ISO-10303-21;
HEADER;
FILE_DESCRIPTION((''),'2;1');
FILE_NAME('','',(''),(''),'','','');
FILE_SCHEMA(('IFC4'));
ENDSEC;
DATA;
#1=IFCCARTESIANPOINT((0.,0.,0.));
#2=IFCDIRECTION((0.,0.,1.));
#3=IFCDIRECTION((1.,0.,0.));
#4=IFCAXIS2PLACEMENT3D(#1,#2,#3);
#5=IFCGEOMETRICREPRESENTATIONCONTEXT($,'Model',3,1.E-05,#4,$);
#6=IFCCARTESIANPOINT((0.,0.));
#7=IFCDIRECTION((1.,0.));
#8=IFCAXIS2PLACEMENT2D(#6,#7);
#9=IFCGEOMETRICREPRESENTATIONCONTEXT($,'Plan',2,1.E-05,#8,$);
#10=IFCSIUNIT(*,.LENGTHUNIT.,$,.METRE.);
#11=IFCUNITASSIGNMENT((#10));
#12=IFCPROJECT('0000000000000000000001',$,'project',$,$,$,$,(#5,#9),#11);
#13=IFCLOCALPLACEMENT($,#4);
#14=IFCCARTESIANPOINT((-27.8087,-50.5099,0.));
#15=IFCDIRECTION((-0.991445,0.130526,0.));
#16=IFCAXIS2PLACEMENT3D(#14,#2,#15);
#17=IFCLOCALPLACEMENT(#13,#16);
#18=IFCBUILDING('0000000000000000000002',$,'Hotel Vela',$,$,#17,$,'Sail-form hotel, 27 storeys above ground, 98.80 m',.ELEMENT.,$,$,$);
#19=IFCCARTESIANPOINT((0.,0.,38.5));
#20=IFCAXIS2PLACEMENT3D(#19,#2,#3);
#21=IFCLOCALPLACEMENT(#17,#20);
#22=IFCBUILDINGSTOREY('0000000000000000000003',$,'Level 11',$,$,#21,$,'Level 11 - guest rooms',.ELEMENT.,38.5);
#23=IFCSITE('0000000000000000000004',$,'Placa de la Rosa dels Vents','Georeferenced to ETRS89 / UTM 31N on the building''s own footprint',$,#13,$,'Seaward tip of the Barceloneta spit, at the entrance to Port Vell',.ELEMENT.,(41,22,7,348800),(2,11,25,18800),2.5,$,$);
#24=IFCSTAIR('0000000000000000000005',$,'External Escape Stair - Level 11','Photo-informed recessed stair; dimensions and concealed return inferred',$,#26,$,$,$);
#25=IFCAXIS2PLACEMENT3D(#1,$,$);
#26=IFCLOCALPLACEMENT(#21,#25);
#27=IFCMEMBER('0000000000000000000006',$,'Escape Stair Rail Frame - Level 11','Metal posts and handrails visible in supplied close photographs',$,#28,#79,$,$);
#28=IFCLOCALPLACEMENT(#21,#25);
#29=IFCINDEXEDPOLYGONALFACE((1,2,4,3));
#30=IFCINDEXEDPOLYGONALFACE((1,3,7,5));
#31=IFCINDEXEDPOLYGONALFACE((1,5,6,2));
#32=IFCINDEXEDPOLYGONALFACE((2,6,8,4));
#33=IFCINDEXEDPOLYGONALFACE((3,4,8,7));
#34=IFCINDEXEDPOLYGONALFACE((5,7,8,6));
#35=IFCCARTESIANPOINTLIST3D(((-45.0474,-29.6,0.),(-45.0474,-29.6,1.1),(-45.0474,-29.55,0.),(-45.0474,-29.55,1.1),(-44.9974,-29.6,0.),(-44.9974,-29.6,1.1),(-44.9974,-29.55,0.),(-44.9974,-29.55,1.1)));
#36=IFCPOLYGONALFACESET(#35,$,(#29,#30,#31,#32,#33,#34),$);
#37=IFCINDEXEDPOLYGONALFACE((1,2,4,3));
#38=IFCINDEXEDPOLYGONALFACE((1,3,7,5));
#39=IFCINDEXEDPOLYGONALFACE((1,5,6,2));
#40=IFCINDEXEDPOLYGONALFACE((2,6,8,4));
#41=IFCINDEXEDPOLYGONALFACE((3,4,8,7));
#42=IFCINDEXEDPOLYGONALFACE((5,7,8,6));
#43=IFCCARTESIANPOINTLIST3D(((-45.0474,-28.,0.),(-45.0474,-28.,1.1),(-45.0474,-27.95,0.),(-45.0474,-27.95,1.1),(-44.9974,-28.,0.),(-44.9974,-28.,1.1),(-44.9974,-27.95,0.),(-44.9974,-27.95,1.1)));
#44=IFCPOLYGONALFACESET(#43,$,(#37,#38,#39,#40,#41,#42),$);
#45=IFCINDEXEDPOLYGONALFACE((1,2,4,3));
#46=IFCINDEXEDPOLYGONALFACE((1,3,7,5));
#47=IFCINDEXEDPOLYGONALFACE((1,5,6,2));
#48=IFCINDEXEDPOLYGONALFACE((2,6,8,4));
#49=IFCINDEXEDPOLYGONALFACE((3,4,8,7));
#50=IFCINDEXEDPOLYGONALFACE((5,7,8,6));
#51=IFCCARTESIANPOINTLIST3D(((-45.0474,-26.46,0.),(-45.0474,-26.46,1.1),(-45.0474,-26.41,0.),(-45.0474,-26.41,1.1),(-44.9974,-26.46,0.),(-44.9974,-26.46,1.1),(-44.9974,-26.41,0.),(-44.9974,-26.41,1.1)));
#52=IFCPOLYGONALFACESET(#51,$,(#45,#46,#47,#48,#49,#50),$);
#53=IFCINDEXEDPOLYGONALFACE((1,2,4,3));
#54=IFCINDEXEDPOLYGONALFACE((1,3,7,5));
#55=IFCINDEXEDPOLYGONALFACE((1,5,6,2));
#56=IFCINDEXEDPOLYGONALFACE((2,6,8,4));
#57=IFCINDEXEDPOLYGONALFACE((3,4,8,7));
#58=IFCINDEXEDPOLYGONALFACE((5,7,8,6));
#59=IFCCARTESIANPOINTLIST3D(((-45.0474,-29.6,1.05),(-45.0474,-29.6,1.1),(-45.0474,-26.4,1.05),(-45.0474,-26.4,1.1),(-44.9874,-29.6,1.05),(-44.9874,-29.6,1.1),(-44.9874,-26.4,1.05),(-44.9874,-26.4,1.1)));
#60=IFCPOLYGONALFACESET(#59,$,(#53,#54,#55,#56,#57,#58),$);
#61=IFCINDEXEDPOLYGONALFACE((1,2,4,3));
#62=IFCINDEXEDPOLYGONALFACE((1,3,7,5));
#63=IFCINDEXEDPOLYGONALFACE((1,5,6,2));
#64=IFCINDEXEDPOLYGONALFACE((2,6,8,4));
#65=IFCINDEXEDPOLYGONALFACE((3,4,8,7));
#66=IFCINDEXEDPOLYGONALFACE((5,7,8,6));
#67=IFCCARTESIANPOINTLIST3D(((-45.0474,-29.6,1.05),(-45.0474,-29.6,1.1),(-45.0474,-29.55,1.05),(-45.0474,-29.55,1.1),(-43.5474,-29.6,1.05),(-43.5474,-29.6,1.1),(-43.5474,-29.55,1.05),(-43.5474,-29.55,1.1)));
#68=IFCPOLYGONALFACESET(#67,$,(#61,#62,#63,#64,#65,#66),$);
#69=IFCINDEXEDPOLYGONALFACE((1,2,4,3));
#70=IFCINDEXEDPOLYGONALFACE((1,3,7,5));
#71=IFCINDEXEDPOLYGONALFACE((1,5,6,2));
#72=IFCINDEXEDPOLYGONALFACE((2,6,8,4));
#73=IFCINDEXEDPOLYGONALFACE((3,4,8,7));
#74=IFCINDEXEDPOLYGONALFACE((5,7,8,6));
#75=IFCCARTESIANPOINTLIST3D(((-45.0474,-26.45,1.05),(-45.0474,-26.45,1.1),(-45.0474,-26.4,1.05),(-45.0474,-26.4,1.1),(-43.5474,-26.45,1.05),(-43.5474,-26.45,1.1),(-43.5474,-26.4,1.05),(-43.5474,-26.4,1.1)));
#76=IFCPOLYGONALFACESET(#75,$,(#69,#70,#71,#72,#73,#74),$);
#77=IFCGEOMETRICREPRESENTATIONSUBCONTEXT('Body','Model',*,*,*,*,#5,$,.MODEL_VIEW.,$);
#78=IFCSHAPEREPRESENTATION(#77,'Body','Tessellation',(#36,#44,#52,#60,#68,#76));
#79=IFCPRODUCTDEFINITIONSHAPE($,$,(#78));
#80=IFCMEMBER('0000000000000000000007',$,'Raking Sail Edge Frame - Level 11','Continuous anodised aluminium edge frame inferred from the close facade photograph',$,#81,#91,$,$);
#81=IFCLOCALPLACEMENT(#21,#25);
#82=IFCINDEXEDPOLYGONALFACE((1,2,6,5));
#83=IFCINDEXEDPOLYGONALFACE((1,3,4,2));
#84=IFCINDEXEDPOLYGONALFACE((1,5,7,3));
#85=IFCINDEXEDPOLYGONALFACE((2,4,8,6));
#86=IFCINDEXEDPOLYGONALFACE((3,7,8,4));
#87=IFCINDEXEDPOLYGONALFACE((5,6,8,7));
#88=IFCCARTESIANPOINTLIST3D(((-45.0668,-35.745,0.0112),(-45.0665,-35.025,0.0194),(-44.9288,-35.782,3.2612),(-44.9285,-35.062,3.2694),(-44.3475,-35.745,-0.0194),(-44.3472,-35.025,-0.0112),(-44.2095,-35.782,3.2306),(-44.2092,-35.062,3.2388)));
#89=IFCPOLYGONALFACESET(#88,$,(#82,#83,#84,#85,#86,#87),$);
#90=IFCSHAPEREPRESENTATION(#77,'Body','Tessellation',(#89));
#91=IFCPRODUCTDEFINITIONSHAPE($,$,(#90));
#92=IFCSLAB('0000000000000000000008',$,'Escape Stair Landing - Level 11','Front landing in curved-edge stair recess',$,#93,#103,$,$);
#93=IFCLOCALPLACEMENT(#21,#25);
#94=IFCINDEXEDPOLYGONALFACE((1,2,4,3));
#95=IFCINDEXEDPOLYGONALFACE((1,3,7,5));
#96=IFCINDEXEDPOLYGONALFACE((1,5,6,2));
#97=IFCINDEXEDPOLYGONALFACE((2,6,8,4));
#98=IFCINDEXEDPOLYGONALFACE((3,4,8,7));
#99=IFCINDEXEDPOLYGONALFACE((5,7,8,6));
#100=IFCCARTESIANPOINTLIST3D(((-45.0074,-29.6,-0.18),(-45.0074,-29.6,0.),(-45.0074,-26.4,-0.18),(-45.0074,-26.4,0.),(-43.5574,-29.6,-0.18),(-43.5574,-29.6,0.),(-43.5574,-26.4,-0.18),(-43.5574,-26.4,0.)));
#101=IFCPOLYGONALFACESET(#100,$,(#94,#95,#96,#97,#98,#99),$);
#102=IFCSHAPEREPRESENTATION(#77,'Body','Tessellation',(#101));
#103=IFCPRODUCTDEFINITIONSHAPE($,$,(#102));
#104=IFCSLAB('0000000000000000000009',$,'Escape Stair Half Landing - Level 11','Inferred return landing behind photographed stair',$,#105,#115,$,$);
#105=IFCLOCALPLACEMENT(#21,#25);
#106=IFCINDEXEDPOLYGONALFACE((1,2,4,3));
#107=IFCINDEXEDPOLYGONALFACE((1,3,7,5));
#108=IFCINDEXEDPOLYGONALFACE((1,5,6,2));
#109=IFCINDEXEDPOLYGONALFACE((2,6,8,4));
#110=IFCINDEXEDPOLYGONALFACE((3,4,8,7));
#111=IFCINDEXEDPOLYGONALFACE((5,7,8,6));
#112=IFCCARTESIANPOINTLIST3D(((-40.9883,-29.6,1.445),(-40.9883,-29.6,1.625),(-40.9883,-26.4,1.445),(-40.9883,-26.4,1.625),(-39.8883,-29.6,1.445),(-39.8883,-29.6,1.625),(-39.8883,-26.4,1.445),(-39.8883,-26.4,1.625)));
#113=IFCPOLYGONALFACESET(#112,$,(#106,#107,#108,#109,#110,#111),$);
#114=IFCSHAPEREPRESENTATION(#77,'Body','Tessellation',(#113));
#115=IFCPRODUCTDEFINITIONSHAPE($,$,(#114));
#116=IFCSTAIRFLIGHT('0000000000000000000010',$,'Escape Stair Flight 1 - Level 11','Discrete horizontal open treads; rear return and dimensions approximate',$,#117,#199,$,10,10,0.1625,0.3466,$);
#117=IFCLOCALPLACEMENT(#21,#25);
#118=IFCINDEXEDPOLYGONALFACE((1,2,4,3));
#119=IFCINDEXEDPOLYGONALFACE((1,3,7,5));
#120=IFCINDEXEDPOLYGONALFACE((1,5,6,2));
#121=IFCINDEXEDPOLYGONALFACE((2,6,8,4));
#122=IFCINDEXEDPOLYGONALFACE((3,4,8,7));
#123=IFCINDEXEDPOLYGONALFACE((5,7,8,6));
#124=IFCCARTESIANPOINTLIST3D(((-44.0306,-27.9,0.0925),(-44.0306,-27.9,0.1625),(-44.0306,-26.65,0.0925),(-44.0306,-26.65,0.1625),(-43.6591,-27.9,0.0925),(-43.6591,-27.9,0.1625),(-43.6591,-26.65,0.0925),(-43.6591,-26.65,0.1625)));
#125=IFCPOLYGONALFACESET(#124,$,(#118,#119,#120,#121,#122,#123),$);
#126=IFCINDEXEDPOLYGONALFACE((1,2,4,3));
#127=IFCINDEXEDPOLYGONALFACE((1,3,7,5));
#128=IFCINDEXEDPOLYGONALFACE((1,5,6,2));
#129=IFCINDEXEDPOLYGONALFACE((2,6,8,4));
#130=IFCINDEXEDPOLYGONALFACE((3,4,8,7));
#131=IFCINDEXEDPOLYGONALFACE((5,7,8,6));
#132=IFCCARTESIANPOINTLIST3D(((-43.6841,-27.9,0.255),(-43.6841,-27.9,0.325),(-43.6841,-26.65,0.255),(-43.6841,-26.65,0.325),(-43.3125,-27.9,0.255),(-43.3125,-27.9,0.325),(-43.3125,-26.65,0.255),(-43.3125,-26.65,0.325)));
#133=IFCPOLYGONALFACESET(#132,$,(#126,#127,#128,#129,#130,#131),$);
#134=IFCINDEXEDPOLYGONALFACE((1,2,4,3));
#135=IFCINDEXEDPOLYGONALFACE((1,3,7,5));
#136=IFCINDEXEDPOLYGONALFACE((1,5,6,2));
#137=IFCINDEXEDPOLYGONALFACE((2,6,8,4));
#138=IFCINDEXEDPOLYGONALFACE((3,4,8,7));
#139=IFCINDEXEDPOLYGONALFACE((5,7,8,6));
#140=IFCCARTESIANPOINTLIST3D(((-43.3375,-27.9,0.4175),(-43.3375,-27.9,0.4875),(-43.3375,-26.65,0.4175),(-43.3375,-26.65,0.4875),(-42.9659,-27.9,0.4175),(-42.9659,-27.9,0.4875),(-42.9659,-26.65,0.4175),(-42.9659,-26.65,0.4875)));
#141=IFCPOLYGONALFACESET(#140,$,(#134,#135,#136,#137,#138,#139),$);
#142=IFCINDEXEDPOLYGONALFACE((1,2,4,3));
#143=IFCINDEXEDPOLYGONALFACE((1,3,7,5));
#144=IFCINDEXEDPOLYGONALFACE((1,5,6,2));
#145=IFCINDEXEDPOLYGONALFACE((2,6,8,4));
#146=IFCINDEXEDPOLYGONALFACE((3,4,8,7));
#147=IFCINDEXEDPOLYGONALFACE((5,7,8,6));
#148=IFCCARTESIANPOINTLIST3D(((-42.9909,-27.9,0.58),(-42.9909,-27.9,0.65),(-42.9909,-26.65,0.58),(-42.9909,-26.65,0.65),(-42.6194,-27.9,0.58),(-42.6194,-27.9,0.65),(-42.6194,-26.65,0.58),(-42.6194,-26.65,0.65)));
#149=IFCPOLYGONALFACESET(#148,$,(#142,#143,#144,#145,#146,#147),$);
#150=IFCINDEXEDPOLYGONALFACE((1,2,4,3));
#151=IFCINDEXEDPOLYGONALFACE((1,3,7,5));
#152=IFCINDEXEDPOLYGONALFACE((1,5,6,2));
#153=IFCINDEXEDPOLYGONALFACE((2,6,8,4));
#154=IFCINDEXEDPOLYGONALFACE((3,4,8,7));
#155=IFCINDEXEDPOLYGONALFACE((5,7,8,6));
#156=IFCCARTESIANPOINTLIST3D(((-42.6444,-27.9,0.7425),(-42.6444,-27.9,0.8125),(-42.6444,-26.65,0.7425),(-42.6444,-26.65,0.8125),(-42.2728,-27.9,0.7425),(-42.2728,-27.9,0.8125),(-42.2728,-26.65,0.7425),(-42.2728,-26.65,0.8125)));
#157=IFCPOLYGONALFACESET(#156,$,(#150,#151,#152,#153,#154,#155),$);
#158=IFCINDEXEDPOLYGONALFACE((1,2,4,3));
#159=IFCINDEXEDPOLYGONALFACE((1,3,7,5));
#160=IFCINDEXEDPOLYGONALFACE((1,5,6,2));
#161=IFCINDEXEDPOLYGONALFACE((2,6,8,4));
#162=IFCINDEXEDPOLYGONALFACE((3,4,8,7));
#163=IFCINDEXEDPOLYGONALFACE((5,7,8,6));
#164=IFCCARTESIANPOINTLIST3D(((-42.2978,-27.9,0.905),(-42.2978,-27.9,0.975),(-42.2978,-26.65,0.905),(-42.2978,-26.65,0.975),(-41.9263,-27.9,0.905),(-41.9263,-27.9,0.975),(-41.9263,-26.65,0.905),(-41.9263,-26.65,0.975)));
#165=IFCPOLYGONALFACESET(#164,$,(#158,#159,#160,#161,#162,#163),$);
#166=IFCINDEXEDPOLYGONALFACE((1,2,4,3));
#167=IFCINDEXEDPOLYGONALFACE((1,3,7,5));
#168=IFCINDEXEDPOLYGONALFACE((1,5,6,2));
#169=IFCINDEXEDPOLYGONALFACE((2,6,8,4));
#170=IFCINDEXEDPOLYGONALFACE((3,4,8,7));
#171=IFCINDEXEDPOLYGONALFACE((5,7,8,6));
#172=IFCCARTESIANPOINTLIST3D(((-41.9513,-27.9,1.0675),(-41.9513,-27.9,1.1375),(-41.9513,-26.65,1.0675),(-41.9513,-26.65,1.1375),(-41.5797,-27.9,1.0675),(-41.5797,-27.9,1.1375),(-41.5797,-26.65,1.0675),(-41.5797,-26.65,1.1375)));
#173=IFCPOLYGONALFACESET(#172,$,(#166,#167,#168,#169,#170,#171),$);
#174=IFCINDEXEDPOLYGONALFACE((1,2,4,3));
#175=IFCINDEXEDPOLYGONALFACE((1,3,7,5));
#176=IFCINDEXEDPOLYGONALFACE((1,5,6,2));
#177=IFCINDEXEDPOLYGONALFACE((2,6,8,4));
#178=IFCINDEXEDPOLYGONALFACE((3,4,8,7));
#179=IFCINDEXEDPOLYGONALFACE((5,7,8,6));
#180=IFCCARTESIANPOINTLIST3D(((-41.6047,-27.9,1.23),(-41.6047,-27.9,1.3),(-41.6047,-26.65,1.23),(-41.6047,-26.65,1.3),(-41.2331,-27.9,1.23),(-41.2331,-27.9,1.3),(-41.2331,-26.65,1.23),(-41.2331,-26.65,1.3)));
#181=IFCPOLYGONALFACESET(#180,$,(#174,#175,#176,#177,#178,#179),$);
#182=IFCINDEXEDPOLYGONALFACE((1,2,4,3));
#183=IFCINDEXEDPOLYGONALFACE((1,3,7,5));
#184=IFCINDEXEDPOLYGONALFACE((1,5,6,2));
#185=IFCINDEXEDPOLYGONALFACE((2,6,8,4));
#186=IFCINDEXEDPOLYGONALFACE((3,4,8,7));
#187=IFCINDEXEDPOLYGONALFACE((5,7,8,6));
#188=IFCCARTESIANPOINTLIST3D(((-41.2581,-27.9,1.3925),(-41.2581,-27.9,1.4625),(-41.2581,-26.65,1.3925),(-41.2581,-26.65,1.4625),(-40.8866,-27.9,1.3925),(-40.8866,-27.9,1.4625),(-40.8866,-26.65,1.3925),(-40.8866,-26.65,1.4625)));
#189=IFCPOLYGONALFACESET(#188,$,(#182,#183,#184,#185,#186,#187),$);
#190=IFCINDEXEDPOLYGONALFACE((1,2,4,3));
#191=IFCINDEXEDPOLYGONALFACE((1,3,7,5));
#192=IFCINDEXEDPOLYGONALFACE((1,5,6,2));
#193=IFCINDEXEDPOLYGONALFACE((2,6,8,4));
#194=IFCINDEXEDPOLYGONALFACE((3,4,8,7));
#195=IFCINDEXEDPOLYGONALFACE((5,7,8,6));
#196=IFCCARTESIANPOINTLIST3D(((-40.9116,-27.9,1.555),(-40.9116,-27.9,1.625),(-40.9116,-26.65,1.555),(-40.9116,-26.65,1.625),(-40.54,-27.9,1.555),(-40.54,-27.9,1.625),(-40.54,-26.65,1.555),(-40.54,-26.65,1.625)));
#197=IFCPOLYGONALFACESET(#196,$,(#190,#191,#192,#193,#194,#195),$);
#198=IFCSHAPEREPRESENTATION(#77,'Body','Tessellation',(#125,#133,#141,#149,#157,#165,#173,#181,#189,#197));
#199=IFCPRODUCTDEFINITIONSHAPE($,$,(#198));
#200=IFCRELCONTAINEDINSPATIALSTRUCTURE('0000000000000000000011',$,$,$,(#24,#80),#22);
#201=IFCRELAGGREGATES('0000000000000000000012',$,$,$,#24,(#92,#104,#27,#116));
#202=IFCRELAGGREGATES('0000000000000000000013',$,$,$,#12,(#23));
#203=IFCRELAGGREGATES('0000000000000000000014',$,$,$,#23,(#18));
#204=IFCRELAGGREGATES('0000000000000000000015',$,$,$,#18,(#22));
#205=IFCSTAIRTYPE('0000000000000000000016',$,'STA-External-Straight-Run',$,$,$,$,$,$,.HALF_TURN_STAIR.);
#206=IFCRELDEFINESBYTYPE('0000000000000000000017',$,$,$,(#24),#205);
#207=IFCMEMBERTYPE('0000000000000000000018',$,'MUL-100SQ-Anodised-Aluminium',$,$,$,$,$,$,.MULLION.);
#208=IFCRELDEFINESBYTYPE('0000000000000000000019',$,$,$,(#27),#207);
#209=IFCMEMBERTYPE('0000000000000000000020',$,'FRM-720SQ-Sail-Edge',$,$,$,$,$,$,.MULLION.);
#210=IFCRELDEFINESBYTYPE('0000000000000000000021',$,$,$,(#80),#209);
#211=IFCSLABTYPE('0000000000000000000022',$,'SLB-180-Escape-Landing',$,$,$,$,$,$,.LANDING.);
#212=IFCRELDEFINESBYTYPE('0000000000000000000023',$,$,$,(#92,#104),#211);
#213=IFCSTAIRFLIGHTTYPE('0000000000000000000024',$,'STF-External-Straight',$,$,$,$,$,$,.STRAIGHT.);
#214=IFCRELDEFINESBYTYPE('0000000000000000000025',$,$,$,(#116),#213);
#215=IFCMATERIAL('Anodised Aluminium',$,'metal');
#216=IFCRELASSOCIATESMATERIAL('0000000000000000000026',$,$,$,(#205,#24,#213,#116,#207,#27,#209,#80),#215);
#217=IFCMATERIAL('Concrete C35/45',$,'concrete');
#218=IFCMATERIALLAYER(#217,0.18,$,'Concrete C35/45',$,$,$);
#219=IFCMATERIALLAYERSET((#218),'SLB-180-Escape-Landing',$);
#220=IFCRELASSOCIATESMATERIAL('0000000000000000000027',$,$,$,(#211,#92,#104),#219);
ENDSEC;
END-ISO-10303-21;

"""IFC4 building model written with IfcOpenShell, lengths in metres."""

from ifc_helpers import new_model, si_unit, frame, origin_with_axes, origin_2d_with_axis, place, context, subcontext, project, spatial, line, indexed_curve, rectangle, outline, extrude, material, layer, layer_set, layer_usage, material_profile, profile_set, profile_usage, type_object, element, aggregate, save


model = new_model("IFC4")

# Units and contexts
model_context = context("Model", 3, precision=1e-05, world=origin_with_axes())
plan_context = context("Plan", 2, precision=1e-05, world=origin_2d_with_axis())
body_context = subcontext(model_context, "Body", "Model", "MODEL_VIEW")
ifc_project = project(units=[si_unit("LENGTHUNIT", "METRE")], contexts=[model_context, plan_context])

# Site, building, storey
site_placement = place(None, origin_with_axes())
site = spatial("IfcSite", under=ifc_project, at=site_placement, Name="Placa de la Rosa dels Vents", Description="Georeferenced to ETRS89 / UTM 31N on the building's own footprint", LongName="Seaward tip of the Barceloneta spit, at the entrance to Port Vell", CompositionType="ELEMENT", RefLatitude=(41, 22, 7, 348800), RefLongitude=(2, 11, 25, 18800), RefElevation=2.5)
building_placement = place(site_placement, frame((-27.8087, -50.5099, 0.0), z_axis=(0.0, 0.0, 1.0), x_axis=(-0.991445, 0.130526, 0.0)))
building = spatial("IfcBuilding", under=site, at=building_placement, Name="Hotel Vela", LongName="Sail-form hotel, 27 storeys above ground, 98.80 m", CompositionType="ELEMENT")
storey_placement = place(building_placement, frame((0.0, 0.0, 38.5), z_axis=(0.0, 0.0, 1.0), x_axis=(1.0, 0.0, 0.0)))
storey = spatial("IfcBuildingStorey", under=building, at=storey_placement, Name="Level 11", LongName="Level 11 - guest rooms", CompositionType="ELEMENT", Elevation=38.5)

# Stair, member
ifc_material_1 = material(Name="Anodised Aluminium", Category="metal")
stair_type = type_object("IfcStairType", Name="STA-External-Straight-Run", PredefinedType="HALF_TURN_STAIR", material=ifc_material_1)
stair_placement = place(storey_placement, frame((0.0, 0.0, -38.5), z_axis=(0.0, 0.0, 1.0), x_axis=(1.0, 0.0, 0.0)))
stair = element("IfcStair", 1, at=stair_placement, inside=storey, type_object=stair_type, material=ifc_material_1, Name="External Escape Stair - Level 11", Description="Photo-informed recessed stair; dimensions and concealed return inferred")
ifc_material_profile_1 = material_profile(ifc_material_1, rectangle(XDim=0.1, YDim=0.1))
ifc_profile_set_1 = profile_set([ifc_material_profile_1], Name="MUL-100SQ-Anodised-Aluminium")
ifc_profile_usage_1 = profile_usage(ifc_profile_set_1)
member_type_1 = type_object("IfcMemberType", Name="MUL-100SQ-Anodised-Aluminium", PredefinedType="MULLION", material=ifc_profile_set_1)
member_1_placement = place(stair_placement, origin_with_axes())
member_1 = element("IfcMember", 2, at=member_1_placement, type_object=member_type_1, material=ifc_profile_usage_1, Name="Escape Stair Rail Frame - Level 11", Description="Metal posts and handrails visible in supplied close photographs", context=body_context, shape_type="SweptSolid", body=[
    extrude(outline(indexed_curve([(0.0, 0.0), (0.05, 0.0), (0.05, 0.05), (0.0, 0.05)], segments=[line(1, 2, 3, 4, 1)])), frame((-45.0474, -29.6, 38.5), z_axis=(0.0, 0.0, 1.0), x_axis=(1.0, 0.0, 0.0)), (0.0, 0.0, 1.0), 1.1),
    extrude(outline(indexed_curve([(0.0, 0.0), (0.05, 0.0), (0.05, 0.05), (0.0, 0.05)], segments=[line(1, 2, 3, 4, 1)])), frame((-45.0474, -28.0, 38.5), z_axis=(0.0, 0.0, 1.0), x_axis=(1.0, 0.0, 0.0)), (0.0, 0.0, 1.0), 1.1),
    extrude(outline(indexed_curve([(0.0, 0.0), (0.05, 0.0), (0.05, 0.05), (0.0, 0.05)], segments=[line(1, 2, 3, 4, 1)])), frame((-45.0474, -26.46, 38.5), z_axis=(0.0, 0.0, 1.0), x_axis=(1.0, 0.0, 0.0)), (0.0, 0.0, 1.0), 1.1),
    extrude(outline(indexed_curve([(0.0, 0.0), (0.06, 0.0), (0.06, 3.2), (0.0, 3.2)], segments=[line(1, 2, 3, 4, 1)])), frame((-45.0474, -29.6, 39.55), z_axis=(0.0, 0.0, 1.0), x_axis=(1.0, 0.0, 0.0)), (0.0, 0.0, 1.0), 0.05),
    extrude(outline(indexed_curve([(0.0, 0.0), (1.5, 0.0), (1.5, 0.05), (0.0, 0.05)], segments=[line(1, 2, 3, 4, 1)])), frame((-45.0474, -29.6, 39.55), z_axis=(0.0, 0.0, 1.0), x_axis=(1.0, 0.0, 0.0)), (0.0, 0.0, 1.0), 0.05),
    extrude(outline(indexed_curve([(0.0, 0.0), (1.5, 0.0), (1.5, 0.05), (0.0, 0.05)], segments=[line(1, 2, 3, 4, 1)])), frame((-45.0474, -26.45, 39.55), z_axis=(0.0, 0.0, 1.0), x_axis=(1.0, 0.0, 0.0)), (0.0, 0.0, 1.0), 0.05),
])

# Member
ifc_material_profile_2 = material_profile(ifc_material_1, rectangle(XDim=0.72, YDim=0.72))
ifc_profile_set_2 = profile_set([ifc_material_profile_2], Name="FRM-720SQ-Sail-Edge")
ifc_profile_usage_2 = profile_usage(ifc_profile_set_2)
member_type_2 = type_object("IfcMemberType", Name="FRM-720SQ-Sail-Edge", PredefinedType="MULLION", material=ifc_profile_set_2)
member_2_placement = place(storey_placement, frame((-44.707, -35.385, 0.0), z_axis=(0.042421, -0.011374, 0.999035), x_axis=(0.9991, 0.0, -0.042423)))
element("IfcMember", 3, at=member_2_placement, inside=storey, type_object=member_type_2, material=ifc_profile_usage_2, Name="Raking Sail Edge Frame - Level 11", Description="Continuous anodised aluminium edge frame inferred from the close facade photograph", context=body_context, shape_type="SweptSolid", body=[
    extrude(outline(indexed_curve([(-0.36, -0.36), (0.36, -0.36), (0.36, 0.36), (-0.36, 0.36)], segments=[line(1, 2, 3, 4, 1)])), origin_with_axes(), (0.0, 0.0, 1.0), 3.2531),
])

# Slabs
ifc_material_2 = material(Name="Concrete C35/45", Category="concrete")
ifc_layer = layer(ifc_material_2, 0.18, Name="Concrete C35/45")
ifc_layer_set = layer_set([ifc_layer], Name="SLB-180-Escape-Landing")
ifc_layer_usage_1 = layer_usage(ifc_layer_set, "AXIS3", "POSITIVE", 0.0)
slab_type = type_object("IfcSlabType", Name="SLB-180-Escape-Landing", PredefinedType="LANDING", material=ifc_layer_set)
slab_1_placement = place(stair_placement, frame((-45.0074, -29.6, 38.32), z_axis=(0.0, 0.0, 1.0), x_axis=(1.0, 0.0, 0.0)))
slab_1 = element("IfcSlab", 4, at=slab_1_placement, type_object=slab_type, material=ifc_layer_usage_1, Name="Escape Stair Landing - Level 11", Description="Front landing in curved-edge stair recess", context=body_context, shape_type="SweptSolid", body=[
    extrude(outline(indexed_curve([(0.0, 0.0), (1.45, 0.0), (1.45, 3.2), (0.0, 3.2)], segments=[line(1, 2, 3, 4, 1)])), origin_with_axes(), (0.0, 0.0, 1.0), 0.18),
])
ifc_layer_usage_2 = layer_usage(ifc_layer_set, "AXIS3", "POSITIVE", 0.0)
slab_2_placement = place(stair_placement, frame((-40.9883, -29.6, 39.945), z_axis=(0.0, 0.0, 1.0), x_axis=(1.0, 0.0, 0.0)))
slab_2 = element("IfcSlab", 5, at=slab_2_placement, type_object=slab_type, material=ifc_layer_usage_2, Name="Escape Stair Half Landing - Level 11", Description="Inferred return landing behind photographed stair", context=body_context, shape_type="SweptSolid", body=[
    extrude(outline(indexed_curve([(0.0, 0.0), (1.1, 0.0), (1.1, 3.2), (0.0, 3.2)], segments=[line(1, 2, 3, 4, 1)])), origin_with_axes(), (0.0, 0.0, 1.0), 0.18),
])

# Stair flight
stair_flight_type = type_object("IfcStairFlightType", Name="STF-External-Straight", PredefinedType="STRAIGHT", material=ifc_material_1)
stair_flight_1_placement = place(stair_placement, origin_with_axes())
stair_flight_1 = element("IfcStairFlight", 6, at=stair_flight_1_placement, type_object=stair_flight_type, material=ifc_material_1, Name="Escape Stair Flight 1 - Level 11", Description="Discrete horizontal open treads; rear return and dimensions approximate", NumberOfRisers=10, NumberOfTreads=10, RiserHeight=0.1625, TreadLength=0.3466, context=body_context, shape_type="SweptSolid", body=[
    extrude(outline(indexed_curve([(0.0, 0.0), (0.3716, 0.0), (0.3716, 1.25), (0.0, 1.25)], segments=[line(1, 2, 3, 4, 1)])), frame((-44.0306, -27.9, 38.5925), z_axis=(0.0, 0.0, 1.0), x_axis=(1.0, 0.0, 0.0)), (0.0, 0.0, 1.0), 0.07),
    extrude(outline(indexed_curve([(0.0, 0.0), (0.3716, 0.0), (0.3716, 1.25), (0.0, 1.25)], segments=[line(1, 2, 3, 4, 1)])), frame((-43.6841, -27.9, 38.755), z_axis=(0.0, 0.0, 1.0), x_axis=(1.0, 0.0, 0.0)), (0.0, 0.0, 1.0), 0.07),
    extrude(outline(indexed_curve([(0.0, 0.0), (0.3716, 0.0), (0.3716, 1.25), (0.0, 1.25)], segments=[line(1, 2, 3, 4, 1)])), frame((-43.3375, -27.9, 38.9175), z_axis=(0.0, 0.0, 1.0), x_axis=(1.0, 0.0, 0.0)), (0.0, 0.0, 1.0), 0.07),
    extrude(outline(indexed_curve([(0.0, 0.0), (0.3716, 0.0), (0.3716, 1.25), (0.0, 1.25)], segments=[line(1, 2, 3, 4, 1)])), frame((-42.9909, -27.9, 39.08), z_axis=(0.0, 0.0, 1.0), x_axis=(1.0, 0.0, 0.0)), (0.0, 0.0, 1.0), 0.07),
    extrude(outline(indexed_curve([(0.0, 0.0), (0.3716, 0.0), (0.3716, 1.25), (0.0, 1.25)], segments=[line(1, 2, 3, 4, 1)])), frame((-42.6444, -27.9, 39.2425), z_axis=(0.0, 0.0, 1.0), x_axis=(1.0, 0.0, 0.0)), (0.0, 0.0, 1.0), 0.07),
    extrude(outline(indexed_curve([(0.0, 0.0), (0.3716, 0.0), (0.3716, 1.25), (0.0, 1.25)], segments=[line(1, 2, 3, 4, 1)])), frame((-42.2978, -27.9, 39.405), z_axis=(0.0, 0.0, 1.0), x_axis=(1.0, 0.0, 0.0)), (0.0, 0.0, 1.0), 0.07),
    extrude(outline(indexed_curve([(0.0, 0.0), (0.3716, 0.0), (0.3716, 1.25), (0.0, 1.25)], segments=[line(1, 2, 3, 4, 1)])), frame((-41.9513, -27.9, 39.5675), z_axis=(0.0, 0.0, 1.0), x_axis=(1.0, 0.0, 0.0)), (0.0, 0.0, 1.0), 0.07),
    extrude(outline(indexed_curve([(0.0, 0.0), (0.3716, 0.0), (0.3716, 1.25), (0.0, 1.25)], segments=[line(1, 2, 3, 4, 1)])), frame((-41.6047, -27.9, 39.73), z_axis=(0.0, 0.0, 1.0), x_axis=(1.0, 0.0, 0.0)), (0.0, 0.0, 1.0), 0.07),
    extrude(outline(indexed_curve([(0.0, 0.0), (0.3716, 0.0), (0.3716, 1.25), (0.0, 1.25)], segments=[line(1, 2, 3, 4, 1)])), frame((-41.2581, -27.9, 39.8925), z_axis=(0.0, 0.0, 1.0), x_axis=(1.0, 0.0, 0.0)), (0.0, 0.0, 1.0), 0.07),
    extrude(outline(indexed_curve([(0.0, 0.0), (0.3716, 0.0), (0.3716, 1.25), (0.0, 1.25)], segments=[line(1, 2, 3, 4, 1)])), frame((-40.9116, -27.9, 40.055), z_axis=(0.0, 0.0, 1.0), x_axis=(1.0, 0.0, 0.0)), (0.0, 0.0, 1.0), 0.07),
])

aggregate(stair, [slab_1, slab_2, member_1, stair_flight_1])

save(model, "model.ifc")
